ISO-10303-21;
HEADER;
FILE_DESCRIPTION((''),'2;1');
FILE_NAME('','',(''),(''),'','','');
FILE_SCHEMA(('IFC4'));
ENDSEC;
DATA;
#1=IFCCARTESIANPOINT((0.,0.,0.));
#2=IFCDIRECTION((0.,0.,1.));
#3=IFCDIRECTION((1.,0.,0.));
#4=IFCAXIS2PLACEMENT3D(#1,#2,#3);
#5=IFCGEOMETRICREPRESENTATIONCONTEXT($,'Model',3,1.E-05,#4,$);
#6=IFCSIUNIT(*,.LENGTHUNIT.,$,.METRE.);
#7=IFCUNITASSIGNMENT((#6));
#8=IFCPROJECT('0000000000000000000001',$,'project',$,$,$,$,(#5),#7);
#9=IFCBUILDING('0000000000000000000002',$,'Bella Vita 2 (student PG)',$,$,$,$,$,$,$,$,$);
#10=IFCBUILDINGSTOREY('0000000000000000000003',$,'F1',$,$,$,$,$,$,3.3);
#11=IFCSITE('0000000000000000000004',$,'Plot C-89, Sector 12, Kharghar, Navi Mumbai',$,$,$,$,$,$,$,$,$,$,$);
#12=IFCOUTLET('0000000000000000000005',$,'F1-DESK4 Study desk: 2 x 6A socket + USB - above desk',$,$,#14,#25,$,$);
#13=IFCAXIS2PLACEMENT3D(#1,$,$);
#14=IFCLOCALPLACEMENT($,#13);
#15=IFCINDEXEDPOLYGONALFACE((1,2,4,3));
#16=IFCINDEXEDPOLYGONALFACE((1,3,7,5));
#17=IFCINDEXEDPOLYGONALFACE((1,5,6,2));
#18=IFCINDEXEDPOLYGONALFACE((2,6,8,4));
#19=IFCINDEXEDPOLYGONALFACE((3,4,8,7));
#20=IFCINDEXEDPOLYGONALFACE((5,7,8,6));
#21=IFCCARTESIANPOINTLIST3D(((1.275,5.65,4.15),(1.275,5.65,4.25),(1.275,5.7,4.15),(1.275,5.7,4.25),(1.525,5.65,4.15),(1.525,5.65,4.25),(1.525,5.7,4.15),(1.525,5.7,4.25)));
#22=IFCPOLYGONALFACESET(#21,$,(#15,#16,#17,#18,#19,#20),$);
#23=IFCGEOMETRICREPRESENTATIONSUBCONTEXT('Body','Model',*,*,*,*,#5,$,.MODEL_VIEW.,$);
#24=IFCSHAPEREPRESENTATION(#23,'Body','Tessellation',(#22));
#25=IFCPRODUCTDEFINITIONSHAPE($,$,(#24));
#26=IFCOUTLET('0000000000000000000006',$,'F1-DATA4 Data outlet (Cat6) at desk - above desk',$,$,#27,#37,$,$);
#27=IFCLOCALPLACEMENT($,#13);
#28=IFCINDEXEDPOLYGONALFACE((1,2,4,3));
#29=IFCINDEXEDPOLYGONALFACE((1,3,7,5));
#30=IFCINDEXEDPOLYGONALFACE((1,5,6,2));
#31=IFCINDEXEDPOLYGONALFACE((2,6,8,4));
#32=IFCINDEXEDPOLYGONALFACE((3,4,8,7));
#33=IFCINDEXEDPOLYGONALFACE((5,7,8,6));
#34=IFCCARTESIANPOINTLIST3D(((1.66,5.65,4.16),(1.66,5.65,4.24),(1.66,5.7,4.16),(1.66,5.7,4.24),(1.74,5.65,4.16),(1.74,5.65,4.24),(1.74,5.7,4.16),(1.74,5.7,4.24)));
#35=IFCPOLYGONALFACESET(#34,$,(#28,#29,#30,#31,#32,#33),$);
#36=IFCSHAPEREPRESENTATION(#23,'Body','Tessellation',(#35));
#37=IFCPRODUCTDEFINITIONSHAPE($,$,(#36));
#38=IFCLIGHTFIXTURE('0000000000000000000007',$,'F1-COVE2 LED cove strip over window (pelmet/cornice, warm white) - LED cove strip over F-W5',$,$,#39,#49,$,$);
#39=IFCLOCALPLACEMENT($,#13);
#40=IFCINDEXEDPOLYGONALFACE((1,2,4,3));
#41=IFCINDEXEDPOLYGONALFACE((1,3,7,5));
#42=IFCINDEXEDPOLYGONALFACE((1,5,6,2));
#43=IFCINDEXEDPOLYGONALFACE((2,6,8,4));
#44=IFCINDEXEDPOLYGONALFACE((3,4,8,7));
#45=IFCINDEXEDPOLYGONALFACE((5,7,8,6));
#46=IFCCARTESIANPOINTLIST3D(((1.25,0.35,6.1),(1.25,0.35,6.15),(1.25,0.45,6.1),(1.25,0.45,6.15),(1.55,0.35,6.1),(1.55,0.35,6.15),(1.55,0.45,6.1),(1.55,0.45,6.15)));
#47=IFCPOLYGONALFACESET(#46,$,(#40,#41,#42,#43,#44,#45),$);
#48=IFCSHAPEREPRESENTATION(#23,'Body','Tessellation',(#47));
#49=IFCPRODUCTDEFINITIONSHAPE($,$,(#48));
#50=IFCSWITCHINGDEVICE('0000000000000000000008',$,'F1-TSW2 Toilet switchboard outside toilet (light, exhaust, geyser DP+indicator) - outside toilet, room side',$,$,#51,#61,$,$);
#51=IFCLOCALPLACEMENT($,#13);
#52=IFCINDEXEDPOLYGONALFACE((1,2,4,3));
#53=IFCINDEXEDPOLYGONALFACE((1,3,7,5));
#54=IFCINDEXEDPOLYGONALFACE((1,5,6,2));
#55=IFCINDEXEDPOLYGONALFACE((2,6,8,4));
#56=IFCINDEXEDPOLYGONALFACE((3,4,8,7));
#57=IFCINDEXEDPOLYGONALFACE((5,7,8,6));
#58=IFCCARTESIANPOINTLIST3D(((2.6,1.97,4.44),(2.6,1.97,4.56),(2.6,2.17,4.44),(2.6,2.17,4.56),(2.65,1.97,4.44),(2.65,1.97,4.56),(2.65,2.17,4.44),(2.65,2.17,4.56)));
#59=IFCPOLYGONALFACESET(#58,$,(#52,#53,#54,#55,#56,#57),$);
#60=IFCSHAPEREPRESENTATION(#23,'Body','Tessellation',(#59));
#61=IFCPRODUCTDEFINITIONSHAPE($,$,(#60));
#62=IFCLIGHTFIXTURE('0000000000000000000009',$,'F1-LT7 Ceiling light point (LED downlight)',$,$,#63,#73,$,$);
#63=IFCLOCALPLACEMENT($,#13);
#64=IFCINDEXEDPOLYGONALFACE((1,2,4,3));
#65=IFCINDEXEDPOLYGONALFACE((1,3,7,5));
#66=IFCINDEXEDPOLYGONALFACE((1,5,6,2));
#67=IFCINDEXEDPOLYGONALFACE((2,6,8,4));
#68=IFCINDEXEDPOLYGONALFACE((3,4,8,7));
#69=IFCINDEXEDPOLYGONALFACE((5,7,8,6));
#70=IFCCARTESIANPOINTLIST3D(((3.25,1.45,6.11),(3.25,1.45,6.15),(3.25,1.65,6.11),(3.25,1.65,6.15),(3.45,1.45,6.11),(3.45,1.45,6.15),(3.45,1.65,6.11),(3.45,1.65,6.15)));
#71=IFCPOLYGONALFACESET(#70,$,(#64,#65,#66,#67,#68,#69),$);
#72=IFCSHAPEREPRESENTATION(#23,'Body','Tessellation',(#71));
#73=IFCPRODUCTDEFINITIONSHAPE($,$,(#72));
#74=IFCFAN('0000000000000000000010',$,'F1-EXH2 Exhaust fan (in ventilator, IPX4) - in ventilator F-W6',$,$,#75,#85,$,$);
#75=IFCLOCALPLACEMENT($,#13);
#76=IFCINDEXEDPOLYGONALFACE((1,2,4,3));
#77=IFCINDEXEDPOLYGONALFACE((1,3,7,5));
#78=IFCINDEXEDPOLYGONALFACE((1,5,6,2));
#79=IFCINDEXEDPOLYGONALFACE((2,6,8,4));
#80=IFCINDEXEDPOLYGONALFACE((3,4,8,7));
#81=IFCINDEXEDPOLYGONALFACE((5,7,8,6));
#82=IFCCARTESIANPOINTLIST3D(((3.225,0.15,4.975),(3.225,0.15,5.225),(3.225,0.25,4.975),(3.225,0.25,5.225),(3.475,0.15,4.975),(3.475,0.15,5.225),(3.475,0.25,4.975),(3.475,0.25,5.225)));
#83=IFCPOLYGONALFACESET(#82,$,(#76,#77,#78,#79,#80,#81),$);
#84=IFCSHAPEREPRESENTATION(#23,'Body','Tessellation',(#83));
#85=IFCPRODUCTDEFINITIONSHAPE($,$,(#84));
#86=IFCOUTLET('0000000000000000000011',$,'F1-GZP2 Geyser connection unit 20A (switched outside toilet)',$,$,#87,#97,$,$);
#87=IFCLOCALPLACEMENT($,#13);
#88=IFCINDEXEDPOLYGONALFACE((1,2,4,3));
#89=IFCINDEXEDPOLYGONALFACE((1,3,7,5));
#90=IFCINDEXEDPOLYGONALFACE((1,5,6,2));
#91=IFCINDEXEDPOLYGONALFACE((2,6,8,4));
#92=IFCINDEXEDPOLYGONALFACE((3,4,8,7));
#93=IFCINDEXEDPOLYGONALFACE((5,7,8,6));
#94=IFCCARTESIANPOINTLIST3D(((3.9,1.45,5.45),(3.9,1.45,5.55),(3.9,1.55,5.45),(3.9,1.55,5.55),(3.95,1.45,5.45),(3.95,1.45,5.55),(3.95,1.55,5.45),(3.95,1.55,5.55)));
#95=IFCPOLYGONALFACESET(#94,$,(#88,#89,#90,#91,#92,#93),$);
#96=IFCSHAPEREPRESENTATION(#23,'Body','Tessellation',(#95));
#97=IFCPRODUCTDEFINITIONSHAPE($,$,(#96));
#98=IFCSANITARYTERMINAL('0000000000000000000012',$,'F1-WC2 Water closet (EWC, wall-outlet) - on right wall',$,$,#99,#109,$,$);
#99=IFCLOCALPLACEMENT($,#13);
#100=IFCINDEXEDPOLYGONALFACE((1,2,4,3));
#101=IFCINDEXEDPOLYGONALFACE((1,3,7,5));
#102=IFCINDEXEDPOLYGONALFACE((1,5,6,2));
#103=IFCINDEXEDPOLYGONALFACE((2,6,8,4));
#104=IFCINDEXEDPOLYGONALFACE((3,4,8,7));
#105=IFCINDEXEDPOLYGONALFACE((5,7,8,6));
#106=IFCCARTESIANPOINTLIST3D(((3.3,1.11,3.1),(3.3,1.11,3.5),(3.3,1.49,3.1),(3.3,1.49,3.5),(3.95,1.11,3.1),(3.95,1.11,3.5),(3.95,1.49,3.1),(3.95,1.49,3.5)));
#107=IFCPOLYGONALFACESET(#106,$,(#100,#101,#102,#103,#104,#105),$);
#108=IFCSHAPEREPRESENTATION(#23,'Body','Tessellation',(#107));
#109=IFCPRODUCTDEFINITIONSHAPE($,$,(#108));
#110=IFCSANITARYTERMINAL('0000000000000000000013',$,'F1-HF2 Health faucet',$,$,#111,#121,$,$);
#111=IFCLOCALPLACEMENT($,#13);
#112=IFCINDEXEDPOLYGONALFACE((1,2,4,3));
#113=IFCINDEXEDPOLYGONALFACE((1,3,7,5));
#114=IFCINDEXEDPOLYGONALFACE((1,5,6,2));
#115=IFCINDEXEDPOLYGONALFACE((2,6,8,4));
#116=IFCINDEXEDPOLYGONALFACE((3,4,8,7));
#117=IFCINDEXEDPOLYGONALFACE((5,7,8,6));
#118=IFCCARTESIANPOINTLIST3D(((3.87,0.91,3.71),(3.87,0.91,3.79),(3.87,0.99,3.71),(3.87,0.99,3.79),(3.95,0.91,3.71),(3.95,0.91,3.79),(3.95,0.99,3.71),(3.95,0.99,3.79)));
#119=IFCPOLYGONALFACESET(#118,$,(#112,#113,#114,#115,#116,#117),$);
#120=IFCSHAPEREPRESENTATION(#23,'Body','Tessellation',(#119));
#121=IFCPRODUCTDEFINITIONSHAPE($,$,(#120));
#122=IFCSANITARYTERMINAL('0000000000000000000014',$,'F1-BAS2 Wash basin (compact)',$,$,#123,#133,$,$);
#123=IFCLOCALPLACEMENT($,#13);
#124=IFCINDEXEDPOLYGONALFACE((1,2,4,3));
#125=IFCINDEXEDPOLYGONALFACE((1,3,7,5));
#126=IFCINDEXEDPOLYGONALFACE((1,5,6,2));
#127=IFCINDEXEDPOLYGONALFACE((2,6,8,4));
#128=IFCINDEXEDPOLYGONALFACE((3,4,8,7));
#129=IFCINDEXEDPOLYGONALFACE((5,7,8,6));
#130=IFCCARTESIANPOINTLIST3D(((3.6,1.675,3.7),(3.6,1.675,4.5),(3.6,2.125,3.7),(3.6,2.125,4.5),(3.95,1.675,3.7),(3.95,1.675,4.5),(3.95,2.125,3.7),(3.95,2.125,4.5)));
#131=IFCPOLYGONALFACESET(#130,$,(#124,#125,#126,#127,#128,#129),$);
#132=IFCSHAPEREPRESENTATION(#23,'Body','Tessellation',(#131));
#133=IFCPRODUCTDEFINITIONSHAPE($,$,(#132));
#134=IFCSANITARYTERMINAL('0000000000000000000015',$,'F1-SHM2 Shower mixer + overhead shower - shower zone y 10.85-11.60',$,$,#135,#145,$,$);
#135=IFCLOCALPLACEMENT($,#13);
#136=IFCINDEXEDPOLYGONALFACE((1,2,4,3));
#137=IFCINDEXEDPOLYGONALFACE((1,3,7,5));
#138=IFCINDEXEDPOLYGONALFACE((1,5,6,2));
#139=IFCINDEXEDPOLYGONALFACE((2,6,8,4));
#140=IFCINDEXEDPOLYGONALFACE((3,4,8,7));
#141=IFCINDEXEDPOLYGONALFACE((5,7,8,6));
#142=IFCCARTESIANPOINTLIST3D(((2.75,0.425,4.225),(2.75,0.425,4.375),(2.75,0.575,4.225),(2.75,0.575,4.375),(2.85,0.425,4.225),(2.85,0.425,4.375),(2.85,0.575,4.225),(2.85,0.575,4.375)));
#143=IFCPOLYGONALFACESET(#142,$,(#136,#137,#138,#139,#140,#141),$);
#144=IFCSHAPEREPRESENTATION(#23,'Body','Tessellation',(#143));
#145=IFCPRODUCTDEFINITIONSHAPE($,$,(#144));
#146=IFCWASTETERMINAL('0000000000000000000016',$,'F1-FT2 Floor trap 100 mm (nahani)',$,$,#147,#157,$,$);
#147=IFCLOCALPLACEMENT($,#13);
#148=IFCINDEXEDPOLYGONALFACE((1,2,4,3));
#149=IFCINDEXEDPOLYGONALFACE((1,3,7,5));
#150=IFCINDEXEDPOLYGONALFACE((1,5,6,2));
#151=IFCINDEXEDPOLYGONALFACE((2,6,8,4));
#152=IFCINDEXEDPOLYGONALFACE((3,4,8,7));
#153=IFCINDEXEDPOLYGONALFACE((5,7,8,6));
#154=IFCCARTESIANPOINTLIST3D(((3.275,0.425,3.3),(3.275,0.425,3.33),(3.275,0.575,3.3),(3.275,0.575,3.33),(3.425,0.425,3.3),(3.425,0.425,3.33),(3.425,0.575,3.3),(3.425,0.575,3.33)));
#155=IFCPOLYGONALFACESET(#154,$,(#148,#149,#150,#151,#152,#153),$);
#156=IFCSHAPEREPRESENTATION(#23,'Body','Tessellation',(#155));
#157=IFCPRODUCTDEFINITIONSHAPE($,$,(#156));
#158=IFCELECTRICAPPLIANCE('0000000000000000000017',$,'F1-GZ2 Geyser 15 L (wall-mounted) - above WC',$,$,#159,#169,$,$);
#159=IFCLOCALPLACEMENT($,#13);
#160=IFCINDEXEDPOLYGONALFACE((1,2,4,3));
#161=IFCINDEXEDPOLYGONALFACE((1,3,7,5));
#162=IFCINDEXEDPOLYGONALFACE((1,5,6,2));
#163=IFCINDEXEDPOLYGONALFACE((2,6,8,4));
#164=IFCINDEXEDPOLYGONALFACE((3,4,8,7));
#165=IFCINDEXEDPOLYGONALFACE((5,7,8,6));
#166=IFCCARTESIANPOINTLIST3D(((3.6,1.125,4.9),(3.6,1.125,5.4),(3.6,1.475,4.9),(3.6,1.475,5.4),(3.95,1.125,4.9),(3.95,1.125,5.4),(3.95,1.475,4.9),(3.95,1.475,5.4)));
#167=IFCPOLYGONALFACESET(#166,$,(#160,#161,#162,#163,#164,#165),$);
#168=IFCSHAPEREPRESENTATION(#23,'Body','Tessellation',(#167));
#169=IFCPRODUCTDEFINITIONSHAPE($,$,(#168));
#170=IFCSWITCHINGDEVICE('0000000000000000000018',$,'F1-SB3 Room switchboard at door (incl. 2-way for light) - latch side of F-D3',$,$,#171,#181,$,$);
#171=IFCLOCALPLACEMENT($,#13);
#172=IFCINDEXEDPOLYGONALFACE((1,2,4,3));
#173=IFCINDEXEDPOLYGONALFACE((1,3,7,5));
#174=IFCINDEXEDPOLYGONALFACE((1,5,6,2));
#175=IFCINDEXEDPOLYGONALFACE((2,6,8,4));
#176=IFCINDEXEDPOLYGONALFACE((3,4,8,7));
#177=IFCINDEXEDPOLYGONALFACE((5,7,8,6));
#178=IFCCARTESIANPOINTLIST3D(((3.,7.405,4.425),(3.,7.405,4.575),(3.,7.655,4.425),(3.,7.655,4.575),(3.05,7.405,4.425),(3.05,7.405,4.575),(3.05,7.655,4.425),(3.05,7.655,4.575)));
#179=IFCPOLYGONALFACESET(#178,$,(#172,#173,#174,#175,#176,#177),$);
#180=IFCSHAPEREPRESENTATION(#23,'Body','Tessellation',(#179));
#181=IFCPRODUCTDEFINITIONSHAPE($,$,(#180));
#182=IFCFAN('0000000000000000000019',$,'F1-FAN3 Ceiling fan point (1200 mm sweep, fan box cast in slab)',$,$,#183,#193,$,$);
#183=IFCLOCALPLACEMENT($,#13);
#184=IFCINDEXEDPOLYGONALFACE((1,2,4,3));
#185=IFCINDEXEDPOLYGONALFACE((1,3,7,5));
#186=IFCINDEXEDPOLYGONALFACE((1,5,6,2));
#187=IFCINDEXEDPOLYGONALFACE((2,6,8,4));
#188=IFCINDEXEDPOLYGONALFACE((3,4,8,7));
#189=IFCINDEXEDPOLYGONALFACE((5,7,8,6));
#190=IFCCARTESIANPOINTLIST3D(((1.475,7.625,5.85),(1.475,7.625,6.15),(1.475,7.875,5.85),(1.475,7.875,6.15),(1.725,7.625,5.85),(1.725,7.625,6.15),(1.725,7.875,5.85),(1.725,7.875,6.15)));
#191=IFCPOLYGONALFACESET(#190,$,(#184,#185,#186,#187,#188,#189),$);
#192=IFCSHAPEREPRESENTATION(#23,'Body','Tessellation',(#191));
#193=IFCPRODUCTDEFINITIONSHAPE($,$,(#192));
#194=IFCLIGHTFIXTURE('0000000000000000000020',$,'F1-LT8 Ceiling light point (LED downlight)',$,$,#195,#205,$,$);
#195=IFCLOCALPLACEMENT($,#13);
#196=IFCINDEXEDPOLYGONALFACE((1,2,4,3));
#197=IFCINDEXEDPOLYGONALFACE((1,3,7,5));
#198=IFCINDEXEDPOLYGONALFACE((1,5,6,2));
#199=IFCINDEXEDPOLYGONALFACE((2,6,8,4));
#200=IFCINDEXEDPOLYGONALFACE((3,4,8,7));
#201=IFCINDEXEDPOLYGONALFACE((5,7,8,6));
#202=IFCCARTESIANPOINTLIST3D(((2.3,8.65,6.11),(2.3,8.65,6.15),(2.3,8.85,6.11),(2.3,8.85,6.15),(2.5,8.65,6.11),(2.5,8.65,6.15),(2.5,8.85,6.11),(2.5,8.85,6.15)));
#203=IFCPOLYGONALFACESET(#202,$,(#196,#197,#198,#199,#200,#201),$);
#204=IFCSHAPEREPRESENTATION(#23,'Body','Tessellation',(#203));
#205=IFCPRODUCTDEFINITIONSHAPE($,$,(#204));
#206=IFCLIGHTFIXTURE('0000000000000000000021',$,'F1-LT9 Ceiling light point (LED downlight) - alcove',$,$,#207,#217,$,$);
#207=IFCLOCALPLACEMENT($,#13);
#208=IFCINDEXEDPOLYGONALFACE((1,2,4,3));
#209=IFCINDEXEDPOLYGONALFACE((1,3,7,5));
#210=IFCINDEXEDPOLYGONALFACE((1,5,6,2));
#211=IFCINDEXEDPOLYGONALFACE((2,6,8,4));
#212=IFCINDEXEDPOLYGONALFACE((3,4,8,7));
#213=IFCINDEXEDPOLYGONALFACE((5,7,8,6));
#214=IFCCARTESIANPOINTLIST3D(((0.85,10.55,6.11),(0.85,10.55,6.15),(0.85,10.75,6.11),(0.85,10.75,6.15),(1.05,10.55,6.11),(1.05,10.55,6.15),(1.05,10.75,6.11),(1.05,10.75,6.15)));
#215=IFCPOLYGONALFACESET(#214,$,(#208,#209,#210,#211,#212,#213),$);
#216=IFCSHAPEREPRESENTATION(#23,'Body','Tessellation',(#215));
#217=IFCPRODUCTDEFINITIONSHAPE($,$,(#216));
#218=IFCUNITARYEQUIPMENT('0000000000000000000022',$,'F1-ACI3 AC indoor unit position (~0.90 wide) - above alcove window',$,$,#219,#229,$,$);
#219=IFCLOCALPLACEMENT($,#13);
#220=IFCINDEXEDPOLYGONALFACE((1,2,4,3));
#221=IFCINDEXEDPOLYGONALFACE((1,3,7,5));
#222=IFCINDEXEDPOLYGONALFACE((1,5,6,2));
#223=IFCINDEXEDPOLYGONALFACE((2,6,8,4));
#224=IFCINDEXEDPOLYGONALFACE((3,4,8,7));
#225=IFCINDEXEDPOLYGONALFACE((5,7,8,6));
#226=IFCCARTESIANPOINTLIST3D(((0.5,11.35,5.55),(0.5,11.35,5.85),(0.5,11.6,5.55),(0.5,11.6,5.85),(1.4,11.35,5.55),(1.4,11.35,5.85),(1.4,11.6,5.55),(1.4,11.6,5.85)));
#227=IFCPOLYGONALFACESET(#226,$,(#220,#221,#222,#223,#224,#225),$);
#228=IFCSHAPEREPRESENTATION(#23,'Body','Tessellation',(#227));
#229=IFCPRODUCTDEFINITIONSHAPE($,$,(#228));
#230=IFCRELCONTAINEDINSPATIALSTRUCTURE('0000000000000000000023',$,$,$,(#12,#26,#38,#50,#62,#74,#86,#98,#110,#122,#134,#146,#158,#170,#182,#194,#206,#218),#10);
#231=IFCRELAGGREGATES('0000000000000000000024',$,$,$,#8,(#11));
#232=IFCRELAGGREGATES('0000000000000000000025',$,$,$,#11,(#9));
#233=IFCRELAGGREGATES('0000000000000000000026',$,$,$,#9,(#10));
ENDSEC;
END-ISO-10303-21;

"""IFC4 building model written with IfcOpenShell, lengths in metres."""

from ifc_helpers import new_model, si_unit, frame, origin, origin_with_axes, origin_2d, place, context, subcontext, project, spatial, rectangle, extrude, element, save


model = new_model("IFC4")

# Units and contexts
model_context = context("Model", 3, precision=1e-05, world=origin_with_axes())
body_context = subcontext(model_context, "Body", "Model", "MODEL_VIEW")
ifc_project = project(units=[si_unit("LENGTHUNIT", "METRE")], contexts=[model_context])

# Site, building, storey
site = spatial("IfcSite", under=ifc_project, Name="Plot C-89, Sector 12, Kharghar, Navi Mumbai")
building = spatial("IfcBuilding", under=site, Name="Bella Vita 2 (student PG)")
storey = spatial("IfcBuildingStorey", under=building, Name="F1", Elevation=3.3)

# Outlets
outlet_1_placement = place(None, origin())
element("IfcOutlet", 1, at=outlet_1_placement, inside=storey, Name="F1-DESK4 Study desk: 2 x 6A socket + USB - above desk", context=body_context, shape_type="SweptSolid", body=[
    extrude(rectangle(XDim=0.25, YDim=0.05, at=origin_2d()), frame((1.4, 5.675, 4.15)), (0.0, 0.0, 1.0), 0.1),
])
outlet_2_placement = place(None, origin())
element("IfcOutlet", 2, at=outlet_2_placement, inside=storey, Name="F1-DATA4 Data outlet (Cat6) at desk - above desk", context=body_context, shape_type="SweptSolid", body=[
    extrude(rectangle(XDim=0.08, YDim=0.05, at=origin_2d()), frame((1.7, 5.675, 4.16)), (0.0, 0.0, 1.0), 0.08),
])

# Light fixture
light_fixture_1_placement = place(None, origin())
element("IfcLightFixture", 3, at=light_fixture_1_placement, inside=storey, Name="F1-COVE2 LED cove strip over window (pelmet/cornice, warm white) - LED cove strip over F-W5", context=body_context, shape_type="SweptSolid", body=[
    extrude(rectangle(XDim=0.3, YDim=0.1, at=origin_2d()), frame((1.4, 0.4, 6.1)), (0.0, 0.0, 1.0), 0.05),
])

# Switching device
switching_device_1_placement = place(None, origin())
element("IfcSwitchingDevice", 4, at=switching_device_1_placement, inside=storey, Name="F1-TSW2 Toilet switchboard outside toilet (light, exhaust, geyser DP+indicator) - outside toilet, room side", context=body_context, shape_type="SweptSolid", body=[
    extrude(rectangle(XDim=0.05, YDim=0.2, at=origin_2d()), frame((2.625, 2.07, 4.44)), (0.0, 0.0, 1.0), 0.12),
])

# Light fixture
light_fixture_2_placement = place(None, origin())
element("IfcLightFixture", 5, at=light_fixture_2_placement, inside=storey, Name="F1-LT7 Ceiling light point (LED downlight)", context=body_context, shape_type="SweptSolid", body=[
    extrude(rectangle(XDim=0.2, YDim=0.2, at=origin_2d()), frame((3.35, 1.55, 6.11)), (0.0, 0.0, 1.0), 0.04),
])

# Fan
fan_1_placement = place(None, origin())
element("IfcFan", 6, at=fan_1_placement, inside=storey, Name="F1-EXH2 Exhaust fan (in ventilator, IPX4) - in ventilator F-W6", context=body_context, shape_type="SweptSolid", body=[
    extrude(rectangle(XDim=0.25, YDim=0.1, at=origin_2d()), frame((3.35, 0.2, 4.975)), (0.0, 0.0, 1.0), 0.25),
])

# Outlet
outlet_3_placement = place(None, origin())
element("IfcOutlet", 7, at=outlet_3_placement, inside=storey, Name="F1-GZP2 Geyser connection unit 20A (switched outside toilet)", context=body_context, shape_type="SweptSolid", body=[
    extrude(rectangle(XDim=0.05, YDim=0.1, at=origin_2d()), frame((3.925, 1.5, 5.45)), (0.0, 0.0, 1.0), 0.1),
])

# Sanitary terminals
sanitary_terminal_1_placement = place(None, origin())
element("IfcSanitaryTerminal", 8, at=sanitary_terminal_1_placement, inside=storey, Name="F1-WC2 Water closet (EWC, wall-outlet) - on right wall", context=body_context, shape_type="SweptSolid", body=[
    extrude(rectangle(XDim=0.65, YDim=0.38, at=origin_2d()), frame((3.625, 1.3, 3.1)), (0.0, 0.0, 1.0), 0.4),
])
sanitary_terminal_2_placement = place(None, origin())
element("IfcSanitaryTerminal", 9, at=sanitary_terminal_2_placement, inside=storey, Name="F1-HF2 Health faucet", context=body_context, shape_type="SweptSolid", body=[
    extrude(rectangle(XDim=0.08, YDim=0.08, at=origin_2d()), frame((3.91, 0.95, 3.71)), (0.0, 0.0, 1.0), 0.08),
])
sanitary_terminal_3_placement = place(None, origin())
element("IfcSanitaryTerminal", 10, at=sanitary_terminal_3_placement, inside=storey, Name="F1-BAS2 Wash basin (compact)", context=body_context, shape_type="SweptSolid", body=[
    extrude(rectangle(XDim=0.35, YDim=0.45, at=origin_2d()), frame((3.775, 1.9, 3.7)), (0.0, 0.0, 1.0), 0.8),
])
sanitary_terminal_4_placement = place(None, origin())
element("IfcSanitaryTerminal", 11, at=sanitary_terminal_4_placement, inside=storey, Name="F1-SHM2 Shower mixer + overhead shower - shower zone y 10.85-11.60", context=body_context, shape_type="SweptSolid", body=[
    extrude(rectangle(XDim=0.1, YDim=0.15, at=origin_2d()), frame((2.8, 0.5, 4.225)), (0.0, 0.0, 1.0), 0.15),
])

# Waste terminal
waste_terminal_1_placement = place(None, origin())
element("IfcWasteTerminal", 12, at=waste_terminal_1_placement, inside=storey, Name="F1-FT2 Floor trap 100 mm (nahani)", context=body_context, shape_type="SweptSolid", body=[
    extrude(rectangle(XDim=0.15, YDim=0.15, at=origin_2d()), frame((3.35, 0.5, 3.3)), (0.0, 0.0, 1.0), 0.03),
])

# Electric appliance
electric_appliance_1_placement = place(None, origin())
element("IfcElectricAppliance", 13, at=electric_appliance_1_placement, inside=storey, Name="F1-GZ2 Geyser 15 L (wall-mounted) - above WC", context=body_context, shape_type="SweptSolid", body=[
    extrude(rectangle(XDim=0.35, YDim=0.35, at=origin_2d()), frame((3.775, 1.3, 4.9)), (0.0, 0.0, 1.0), 0.5),
])

# Switching device
switching_device_2_placement = place(None, origin())
element("IfcSwitchingDevice", 14, at=switching_device_2_placement, inside=storey, Name="F1-SB3 Room switchboard at door (incl. 2-way for light) - latch side of F-D3", context=body_context, shape_type="SweptSolid", body=[
    extrude(rectangle(XDim=0.05, YDim=0.25, at=origin_2d()), frame((3.025, 7.53, 4.425)), (0.0, 0.0, 1.0), 0.15),
])

# Fan
fan_2_placement = place(None, origin())
element("IfcFan", 15, at=fan_2_placement, inside=storey, Name="F1-FAN3 Ceiling fan point (1200 mm sweep, fan box cast in slab)", context=body_context, shape_type="SweptSolid", body=[
    extrude(rectangle(XDim=0.25, YDim=0.25, at=origin_2d()), frame((1.6, 7.75, 5.85)), (0.0, 0.0, 1.0), 0.3),
])

# Light fixtures
light_fixture_3_placement = place(None, origin())
element("IfcLightFixture", 16, at=light_fixture_3_placement, inside=storey, Name="F1-LT8 Ceiling light point (LED downlight)", context=body_context, shape_type="SweptSolid", body=[
    extrude(rectangle(XDim=0.2, YDim=0.2, at=origin_2d()), frame((2.4, 8.75, 6.11)), (0.0, 0.0, 1.0), 0.04),
])
light_fixture_4_placement = place(None, origin())
element("IfcLightFixture", 17, at=light_fixture_4_placement, inside=storey, Name="F1-LT9 Ceiling light point (LED downlight) - alcove", context=body_context, shape_type="SweptSolid", body=[
    extrude(rectangle(XDim=0.2, YDim=0.2, at=origin_2d()), frame((0.95, 10.65, 6.11)), (0.0, 0.0, 1.0), 0.04),
])

# Unitary equipment
unitary_equipment_1_placement = place(None, origin())
element("IfcUnitaryEquipment", 18, at=unitary_equipment_1_placement, inside=storey, Name="F1-ACI3 AC indoor unit position (~0.90 wide) - above alcove window", context=body_context, shape_type="SweptSolid", body=[
    extrude(rectangle(XDim=0.9, YDim=0.25, at=origin_2d()), frame((0.95, 11.475, 5.55)), (0.0, 0.0, 1.0), 0.3),
])

save(model, "model.ifc")
